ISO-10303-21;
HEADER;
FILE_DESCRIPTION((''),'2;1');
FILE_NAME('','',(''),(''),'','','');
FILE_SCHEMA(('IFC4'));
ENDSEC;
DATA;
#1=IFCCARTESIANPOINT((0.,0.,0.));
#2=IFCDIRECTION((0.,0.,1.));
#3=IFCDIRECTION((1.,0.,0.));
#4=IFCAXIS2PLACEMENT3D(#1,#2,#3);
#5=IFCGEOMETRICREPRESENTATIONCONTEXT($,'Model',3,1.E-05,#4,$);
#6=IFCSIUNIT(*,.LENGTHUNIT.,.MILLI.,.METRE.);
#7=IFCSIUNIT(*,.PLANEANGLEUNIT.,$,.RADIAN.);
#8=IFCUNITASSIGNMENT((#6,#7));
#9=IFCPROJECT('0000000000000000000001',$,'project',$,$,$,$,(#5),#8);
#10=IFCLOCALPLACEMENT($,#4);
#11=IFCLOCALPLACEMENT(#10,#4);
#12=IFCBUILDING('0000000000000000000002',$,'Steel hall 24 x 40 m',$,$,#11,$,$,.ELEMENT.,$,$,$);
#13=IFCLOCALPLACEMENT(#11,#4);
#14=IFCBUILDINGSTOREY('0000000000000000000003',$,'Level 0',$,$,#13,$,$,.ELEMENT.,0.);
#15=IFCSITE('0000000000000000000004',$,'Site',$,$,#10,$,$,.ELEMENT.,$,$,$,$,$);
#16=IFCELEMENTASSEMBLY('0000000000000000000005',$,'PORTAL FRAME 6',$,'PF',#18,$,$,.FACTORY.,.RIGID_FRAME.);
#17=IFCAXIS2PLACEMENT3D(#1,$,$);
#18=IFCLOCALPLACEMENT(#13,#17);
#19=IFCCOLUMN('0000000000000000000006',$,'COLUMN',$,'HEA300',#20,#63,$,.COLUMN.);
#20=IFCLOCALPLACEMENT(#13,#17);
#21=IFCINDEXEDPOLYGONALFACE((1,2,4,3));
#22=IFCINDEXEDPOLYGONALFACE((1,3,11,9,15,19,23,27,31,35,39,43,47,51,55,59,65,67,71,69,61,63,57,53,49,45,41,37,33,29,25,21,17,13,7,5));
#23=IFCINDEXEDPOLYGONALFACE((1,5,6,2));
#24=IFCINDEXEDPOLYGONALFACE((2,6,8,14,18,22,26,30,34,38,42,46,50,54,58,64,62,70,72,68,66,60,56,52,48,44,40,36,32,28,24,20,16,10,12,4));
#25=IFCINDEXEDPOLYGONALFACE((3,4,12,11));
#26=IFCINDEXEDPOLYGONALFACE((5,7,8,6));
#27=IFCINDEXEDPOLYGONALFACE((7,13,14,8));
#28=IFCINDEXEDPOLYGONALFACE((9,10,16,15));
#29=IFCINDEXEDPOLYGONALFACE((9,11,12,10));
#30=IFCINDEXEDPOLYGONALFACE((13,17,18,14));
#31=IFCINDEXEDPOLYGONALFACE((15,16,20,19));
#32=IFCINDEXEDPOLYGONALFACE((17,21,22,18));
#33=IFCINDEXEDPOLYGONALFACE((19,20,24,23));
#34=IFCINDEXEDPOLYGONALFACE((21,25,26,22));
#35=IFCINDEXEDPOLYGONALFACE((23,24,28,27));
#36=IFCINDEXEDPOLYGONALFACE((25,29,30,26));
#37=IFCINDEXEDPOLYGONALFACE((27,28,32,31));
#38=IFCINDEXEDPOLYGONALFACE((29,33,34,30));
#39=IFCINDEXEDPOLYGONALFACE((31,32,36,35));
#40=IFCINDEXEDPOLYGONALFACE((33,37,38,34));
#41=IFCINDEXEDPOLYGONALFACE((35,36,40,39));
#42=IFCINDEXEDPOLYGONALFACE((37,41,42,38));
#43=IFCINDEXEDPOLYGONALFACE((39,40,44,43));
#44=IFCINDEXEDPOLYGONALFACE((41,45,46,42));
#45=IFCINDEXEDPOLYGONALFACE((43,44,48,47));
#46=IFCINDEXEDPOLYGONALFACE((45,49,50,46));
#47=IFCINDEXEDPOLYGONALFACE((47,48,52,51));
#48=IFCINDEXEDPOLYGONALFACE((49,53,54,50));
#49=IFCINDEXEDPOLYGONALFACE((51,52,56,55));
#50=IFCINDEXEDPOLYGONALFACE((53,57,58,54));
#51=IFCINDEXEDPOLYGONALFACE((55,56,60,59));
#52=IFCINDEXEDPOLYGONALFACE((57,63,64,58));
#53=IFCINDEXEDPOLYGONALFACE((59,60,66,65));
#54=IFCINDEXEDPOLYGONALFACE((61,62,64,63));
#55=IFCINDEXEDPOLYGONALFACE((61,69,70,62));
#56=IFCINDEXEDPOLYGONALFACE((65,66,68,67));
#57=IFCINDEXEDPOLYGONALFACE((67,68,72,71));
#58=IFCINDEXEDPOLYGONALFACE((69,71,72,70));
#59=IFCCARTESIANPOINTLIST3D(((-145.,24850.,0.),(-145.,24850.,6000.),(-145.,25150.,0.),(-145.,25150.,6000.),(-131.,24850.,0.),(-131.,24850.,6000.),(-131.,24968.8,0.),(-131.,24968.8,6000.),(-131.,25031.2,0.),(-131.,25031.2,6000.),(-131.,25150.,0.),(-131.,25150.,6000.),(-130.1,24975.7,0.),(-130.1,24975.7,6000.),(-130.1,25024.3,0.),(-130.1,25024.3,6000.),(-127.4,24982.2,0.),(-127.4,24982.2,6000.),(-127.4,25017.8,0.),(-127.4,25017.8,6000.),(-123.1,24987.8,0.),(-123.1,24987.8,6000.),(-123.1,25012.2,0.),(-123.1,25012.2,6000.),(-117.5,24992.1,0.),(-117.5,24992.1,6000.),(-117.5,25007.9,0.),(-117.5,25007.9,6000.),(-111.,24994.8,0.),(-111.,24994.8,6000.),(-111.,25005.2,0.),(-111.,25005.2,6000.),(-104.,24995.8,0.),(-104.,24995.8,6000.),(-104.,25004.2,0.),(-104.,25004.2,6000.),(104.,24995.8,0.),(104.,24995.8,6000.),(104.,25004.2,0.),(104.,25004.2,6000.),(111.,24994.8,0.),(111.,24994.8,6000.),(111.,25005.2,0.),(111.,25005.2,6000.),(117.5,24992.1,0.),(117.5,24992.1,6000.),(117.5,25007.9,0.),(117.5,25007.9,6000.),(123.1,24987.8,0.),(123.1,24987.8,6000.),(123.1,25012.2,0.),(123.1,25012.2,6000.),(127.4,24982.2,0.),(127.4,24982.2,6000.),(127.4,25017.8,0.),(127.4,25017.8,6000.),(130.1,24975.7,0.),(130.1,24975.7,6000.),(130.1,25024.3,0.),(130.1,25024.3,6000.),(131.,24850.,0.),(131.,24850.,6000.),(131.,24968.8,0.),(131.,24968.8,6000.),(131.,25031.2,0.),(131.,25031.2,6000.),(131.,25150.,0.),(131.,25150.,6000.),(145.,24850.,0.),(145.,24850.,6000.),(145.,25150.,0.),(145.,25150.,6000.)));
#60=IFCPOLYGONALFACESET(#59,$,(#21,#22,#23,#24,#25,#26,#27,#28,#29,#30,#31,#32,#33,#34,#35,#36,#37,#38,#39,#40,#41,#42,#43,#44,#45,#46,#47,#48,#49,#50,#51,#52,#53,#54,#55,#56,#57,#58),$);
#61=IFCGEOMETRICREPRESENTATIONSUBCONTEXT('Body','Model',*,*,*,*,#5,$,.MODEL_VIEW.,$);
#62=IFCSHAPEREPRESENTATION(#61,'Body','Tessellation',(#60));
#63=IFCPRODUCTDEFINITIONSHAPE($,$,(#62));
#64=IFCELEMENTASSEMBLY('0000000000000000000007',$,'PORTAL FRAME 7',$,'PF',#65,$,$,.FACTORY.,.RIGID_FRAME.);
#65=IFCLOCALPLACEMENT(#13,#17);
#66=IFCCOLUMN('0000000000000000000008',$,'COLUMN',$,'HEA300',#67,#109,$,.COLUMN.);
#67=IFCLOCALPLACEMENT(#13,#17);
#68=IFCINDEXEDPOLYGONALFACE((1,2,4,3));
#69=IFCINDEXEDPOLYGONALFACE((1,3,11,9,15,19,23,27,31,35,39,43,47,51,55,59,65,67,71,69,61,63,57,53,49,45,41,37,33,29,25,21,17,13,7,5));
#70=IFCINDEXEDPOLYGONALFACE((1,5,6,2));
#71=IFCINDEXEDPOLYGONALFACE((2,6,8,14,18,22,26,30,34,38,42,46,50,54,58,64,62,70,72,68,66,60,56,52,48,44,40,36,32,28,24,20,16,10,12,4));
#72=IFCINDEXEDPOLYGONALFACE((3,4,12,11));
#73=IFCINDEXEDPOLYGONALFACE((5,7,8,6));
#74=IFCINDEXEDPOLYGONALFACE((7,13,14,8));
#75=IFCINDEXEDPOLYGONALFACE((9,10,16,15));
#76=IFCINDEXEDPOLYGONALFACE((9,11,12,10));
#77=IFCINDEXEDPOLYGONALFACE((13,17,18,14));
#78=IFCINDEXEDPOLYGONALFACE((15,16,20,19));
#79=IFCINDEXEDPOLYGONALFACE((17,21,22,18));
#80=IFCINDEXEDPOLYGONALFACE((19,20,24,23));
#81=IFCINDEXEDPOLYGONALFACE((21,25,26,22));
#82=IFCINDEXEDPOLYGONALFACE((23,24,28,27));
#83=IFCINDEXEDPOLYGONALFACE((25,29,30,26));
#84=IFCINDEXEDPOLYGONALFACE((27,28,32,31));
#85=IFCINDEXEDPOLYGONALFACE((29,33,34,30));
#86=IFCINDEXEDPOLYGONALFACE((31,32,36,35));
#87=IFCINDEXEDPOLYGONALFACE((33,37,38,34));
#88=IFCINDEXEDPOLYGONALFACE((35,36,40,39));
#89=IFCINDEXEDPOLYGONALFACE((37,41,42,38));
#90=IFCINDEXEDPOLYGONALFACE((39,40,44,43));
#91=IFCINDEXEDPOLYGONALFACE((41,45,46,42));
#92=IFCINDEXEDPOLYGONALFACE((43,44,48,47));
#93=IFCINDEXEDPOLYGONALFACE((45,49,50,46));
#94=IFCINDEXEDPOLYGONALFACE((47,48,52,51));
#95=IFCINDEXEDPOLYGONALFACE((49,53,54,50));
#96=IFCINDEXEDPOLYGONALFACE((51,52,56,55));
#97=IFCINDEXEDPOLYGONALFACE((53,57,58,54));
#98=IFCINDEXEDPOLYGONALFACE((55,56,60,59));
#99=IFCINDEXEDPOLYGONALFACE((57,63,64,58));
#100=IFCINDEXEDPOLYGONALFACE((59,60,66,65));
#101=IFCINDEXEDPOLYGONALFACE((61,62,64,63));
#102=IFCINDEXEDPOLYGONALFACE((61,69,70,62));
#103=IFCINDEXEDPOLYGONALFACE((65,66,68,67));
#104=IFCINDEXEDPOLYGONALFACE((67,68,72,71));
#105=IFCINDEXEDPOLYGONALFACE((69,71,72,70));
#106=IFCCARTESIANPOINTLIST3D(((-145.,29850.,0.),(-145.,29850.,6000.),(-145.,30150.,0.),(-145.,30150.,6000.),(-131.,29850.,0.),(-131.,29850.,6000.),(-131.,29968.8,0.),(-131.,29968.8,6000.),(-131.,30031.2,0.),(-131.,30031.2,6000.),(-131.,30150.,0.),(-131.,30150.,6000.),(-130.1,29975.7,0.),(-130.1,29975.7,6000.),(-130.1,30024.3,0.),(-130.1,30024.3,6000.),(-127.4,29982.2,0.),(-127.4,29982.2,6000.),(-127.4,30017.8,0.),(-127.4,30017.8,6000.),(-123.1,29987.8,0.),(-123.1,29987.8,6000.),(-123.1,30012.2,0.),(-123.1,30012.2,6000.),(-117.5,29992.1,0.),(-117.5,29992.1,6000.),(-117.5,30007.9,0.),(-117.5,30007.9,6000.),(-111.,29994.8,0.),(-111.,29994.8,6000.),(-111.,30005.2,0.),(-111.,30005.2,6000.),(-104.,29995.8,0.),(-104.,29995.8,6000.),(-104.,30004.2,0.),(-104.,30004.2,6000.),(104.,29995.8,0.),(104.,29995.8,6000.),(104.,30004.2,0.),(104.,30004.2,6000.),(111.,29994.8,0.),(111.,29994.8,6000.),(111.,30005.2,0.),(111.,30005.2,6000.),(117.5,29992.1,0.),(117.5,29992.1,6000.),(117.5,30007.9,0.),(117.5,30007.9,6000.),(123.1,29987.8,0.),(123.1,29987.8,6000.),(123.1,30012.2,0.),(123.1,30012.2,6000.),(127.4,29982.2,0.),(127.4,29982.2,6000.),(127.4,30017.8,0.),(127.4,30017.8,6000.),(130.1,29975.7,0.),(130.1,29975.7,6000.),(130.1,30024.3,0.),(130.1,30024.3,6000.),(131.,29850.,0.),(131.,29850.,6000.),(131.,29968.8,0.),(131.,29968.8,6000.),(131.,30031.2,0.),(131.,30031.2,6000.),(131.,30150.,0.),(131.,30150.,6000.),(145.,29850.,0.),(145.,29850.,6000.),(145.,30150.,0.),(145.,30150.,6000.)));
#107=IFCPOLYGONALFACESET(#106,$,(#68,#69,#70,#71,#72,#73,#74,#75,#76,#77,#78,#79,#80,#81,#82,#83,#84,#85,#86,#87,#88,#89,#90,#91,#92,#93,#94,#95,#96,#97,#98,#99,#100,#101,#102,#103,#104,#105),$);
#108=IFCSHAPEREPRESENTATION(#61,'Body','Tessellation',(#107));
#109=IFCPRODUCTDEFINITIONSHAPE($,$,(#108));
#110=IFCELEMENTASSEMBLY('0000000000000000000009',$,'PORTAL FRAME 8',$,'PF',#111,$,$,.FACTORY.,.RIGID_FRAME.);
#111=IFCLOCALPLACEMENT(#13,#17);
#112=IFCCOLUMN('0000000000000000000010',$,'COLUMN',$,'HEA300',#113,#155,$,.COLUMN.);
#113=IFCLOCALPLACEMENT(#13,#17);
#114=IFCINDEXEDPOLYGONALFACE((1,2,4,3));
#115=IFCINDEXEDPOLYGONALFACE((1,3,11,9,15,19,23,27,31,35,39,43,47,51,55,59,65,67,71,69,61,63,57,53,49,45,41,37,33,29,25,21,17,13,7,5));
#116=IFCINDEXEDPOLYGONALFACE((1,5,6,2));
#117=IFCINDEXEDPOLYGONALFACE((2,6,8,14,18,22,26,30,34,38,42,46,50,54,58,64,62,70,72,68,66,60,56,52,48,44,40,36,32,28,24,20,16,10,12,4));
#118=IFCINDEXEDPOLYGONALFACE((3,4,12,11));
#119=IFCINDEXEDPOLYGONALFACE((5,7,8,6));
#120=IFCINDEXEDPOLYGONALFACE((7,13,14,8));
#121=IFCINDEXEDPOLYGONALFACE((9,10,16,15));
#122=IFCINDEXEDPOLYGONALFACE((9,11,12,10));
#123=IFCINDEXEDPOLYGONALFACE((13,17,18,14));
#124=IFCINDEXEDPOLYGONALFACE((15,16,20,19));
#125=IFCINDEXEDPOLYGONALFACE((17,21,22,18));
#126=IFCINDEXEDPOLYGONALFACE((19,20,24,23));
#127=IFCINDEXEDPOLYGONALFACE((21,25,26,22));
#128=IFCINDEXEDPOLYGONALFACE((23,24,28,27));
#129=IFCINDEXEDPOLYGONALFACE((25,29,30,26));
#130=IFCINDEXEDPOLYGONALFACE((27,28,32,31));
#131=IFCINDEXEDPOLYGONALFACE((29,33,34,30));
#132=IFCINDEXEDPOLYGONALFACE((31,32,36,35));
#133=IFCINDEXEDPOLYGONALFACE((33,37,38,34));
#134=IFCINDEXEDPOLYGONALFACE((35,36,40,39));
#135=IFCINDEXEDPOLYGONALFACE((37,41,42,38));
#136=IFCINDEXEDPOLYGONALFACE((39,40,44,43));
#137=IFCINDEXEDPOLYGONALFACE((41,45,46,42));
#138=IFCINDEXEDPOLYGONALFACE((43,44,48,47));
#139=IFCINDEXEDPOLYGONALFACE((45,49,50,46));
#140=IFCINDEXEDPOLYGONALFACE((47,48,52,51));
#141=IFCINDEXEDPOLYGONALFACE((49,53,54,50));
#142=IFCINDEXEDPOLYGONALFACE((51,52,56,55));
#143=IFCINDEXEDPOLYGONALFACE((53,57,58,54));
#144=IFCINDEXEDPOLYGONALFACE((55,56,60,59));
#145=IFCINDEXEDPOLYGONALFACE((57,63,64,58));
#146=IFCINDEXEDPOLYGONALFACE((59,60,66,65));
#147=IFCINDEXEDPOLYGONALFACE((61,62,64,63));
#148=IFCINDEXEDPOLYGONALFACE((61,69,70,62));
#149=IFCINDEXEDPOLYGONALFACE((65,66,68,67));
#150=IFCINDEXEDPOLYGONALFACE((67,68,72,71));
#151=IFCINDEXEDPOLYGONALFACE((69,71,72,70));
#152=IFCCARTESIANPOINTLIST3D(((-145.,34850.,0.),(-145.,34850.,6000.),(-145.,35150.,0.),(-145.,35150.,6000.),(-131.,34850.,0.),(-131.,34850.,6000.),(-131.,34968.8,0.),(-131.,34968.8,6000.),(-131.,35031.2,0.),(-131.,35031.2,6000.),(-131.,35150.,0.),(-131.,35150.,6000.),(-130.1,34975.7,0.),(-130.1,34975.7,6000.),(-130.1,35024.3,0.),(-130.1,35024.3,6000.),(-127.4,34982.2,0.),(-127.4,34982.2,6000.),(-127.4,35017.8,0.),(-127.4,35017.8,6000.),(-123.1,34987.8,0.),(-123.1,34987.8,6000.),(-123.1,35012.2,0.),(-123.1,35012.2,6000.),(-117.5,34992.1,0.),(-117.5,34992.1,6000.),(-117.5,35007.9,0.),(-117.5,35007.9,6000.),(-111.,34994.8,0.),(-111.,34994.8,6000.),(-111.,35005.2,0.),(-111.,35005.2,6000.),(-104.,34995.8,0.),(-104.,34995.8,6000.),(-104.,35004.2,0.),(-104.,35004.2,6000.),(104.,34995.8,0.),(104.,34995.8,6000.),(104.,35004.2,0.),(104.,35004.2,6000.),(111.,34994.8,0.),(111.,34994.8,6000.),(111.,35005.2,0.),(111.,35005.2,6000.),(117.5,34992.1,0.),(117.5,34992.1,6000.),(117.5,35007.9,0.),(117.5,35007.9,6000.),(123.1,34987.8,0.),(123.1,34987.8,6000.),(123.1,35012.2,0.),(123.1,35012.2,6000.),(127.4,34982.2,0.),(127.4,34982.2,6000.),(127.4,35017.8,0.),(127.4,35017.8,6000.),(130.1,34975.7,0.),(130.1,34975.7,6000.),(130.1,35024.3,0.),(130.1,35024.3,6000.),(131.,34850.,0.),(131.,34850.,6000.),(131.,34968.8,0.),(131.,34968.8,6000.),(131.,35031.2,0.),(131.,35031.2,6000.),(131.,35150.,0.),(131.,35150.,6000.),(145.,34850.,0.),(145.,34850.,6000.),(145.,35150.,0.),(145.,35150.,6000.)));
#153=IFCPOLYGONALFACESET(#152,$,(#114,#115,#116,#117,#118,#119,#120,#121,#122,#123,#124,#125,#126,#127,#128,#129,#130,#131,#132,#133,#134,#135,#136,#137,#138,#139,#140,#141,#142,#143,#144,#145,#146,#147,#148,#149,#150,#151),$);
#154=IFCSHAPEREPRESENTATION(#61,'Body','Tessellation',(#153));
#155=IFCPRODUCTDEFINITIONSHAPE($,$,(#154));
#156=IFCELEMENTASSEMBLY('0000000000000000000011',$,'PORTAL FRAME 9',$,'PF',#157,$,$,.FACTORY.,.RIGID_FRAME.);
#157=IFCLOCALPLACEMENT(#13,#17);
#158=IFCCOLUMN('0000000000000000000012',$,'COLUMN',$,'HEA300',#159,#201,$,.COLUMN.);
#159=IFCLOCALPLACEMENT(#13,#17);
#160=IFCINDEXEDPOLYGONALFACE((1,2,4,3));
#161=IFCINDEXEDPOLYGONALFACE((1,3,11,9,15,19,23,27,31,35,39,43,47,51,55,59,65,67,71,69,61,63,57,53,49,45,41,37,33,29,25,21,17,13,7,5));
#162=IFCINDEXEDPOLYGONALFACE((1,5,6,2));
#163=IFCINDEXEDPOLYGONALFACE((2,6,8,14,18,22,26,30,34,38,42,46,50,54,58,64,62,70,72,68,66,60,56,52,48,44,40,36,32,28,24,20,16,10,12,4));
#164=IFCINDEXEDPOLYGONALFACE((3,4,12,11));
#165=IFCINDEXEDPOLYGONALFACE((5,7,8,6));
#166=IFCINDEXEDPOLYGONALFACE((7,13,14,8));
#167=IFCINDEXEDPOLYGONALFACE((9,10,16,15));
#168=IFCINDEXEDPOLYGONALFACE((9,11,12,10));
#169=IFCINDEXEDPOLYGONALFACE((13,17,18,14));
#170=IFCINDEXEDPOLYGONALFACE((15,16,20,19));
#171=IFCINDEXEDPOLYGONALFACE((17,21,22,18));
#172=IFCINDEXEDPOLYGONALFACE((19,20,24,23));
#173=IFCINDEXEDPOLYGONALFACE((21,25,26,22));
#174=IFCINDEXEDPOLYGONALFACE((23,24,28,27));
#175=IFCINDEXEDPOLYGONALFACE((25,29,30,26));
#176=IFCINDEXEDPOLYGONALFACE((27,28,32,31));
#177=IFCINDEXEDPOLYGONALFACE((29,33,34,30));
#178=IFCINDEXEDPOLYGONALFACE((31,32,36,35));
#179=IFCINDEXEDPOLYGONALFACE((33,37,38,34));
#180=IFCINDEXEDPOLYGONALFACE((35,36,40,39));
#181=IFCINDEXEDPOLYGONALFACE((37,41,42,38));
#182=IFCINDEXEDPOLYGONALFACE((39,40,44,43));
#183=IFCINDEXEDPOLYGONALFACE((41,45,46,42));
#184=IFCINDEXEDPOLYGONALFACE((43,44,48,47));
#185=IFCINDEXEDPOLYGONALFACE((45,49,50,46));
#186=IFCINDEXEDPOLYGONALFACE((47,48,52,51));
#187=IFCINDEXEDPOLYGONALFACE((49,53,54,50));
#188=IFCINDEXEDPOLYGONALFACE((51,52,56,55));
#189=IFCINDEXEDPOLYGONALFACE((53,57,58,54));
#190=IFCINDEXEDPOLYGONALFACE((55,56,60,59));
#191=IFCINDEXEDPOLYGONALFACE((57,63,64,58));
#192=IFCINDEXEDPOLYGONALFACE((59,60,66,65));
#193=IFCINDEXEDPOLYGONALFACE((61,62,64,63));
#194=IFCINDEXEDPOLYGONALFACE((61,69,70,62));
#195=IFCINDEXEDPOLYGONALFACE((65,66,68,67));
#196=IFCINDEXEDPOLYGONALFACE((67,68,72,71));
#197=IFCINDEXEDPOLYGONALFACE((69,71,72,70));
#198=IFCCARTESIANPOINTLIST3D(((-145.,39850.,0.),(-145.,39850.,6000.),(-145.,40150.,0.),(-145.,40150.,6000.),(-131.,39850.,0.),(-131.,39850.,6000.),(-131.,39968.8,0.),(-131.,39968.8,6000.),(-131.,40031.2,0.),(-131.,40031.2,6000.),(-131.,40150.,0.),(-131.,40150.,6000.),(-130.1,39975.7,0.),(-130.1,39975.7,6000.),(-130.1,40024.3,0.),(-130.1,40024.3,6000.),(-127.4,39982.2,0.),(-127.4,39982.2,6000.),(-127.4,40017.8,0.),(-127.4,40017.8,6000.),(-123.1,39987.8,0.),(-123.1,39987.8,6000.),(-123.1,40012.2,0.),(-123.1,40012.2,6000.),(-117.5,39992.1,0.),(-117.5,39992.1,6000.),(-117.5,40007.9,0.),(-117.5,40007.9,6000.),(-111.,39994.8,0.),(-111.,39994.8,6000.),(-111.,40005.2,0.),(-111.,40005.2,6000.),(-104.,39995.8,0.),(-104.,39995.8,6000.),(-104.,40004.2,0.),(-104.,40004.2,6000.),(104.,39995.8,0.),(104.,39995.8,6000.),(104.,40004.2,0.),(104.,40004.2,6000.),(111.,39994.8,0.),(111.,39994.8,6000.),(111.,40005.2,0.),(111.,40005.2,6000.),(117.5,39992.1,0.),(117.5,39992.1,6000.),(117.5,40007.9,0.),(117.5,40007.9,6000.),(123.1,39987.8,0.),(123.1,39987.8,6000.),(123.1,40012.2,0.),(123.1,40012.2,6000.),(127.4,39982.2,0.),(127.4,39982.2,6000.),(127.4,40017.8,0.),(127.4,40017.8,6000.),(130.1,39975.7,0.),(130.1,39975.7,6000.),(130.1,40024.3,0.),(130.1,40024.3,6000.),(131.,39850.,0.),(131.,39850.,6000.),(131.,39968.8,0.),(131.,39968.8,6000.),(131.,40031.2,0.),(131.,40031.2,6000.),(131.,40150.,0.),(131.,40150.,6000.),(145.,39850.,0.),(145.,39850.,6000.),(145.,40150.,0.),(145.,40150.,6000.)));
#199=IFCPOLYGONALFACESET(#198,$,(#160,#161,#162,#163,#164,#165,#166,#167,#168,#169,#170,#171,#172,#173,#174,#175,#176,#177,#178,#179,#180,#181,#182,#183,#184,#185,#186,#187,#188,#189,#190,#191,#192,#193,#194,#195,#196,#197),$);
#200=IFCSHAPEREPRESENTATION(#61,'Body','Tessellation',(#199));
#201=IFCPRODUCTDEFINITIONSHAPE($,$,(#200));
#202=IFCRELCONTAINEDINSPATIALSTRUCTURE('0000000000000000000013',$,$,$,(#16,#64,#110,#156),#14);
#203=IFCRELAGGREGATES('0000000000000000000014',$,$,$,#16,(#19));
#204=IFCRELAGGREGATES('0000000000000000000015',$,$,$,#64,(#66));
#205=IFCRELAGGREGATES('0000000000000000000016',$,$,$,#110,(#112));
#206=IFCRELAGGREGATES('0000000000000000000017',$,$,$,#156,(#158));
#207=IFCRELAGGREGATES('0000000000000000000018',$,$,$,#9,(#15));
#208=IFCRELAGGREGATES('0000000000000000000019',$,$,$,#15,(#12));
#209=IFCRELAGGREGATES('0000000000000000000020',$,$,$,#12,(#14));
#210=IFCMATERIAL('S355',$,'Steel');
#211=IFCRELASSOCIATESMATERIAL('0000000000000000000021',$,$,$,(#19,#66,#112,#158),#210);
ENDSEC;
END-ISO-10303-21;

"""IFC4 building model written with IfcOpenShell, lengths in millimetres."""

from ifc_helpers import new_model, si_unit, frame, origin_with_axes, place, context, subcontext, project, spatial, i_section, extrude, material, element, aggregate, save


model = new_model("IFC4")

# Units and contexts
model_context = context("Model", 3, precision=1e-05, world=origin_with_axes())
body_context = subcontext(model_context, "Body", "Model", "MODEL_VIEW")
ifc_project = project(units=[si_unit("LENGTHUNIT", "METRE", prefix="MILLI"), si_unit("PLANEANGLEUNIT", "RADIAN")], contexts=[model_context])

# Site, building, storey
site_placement = place(None, origin_with_axes())
site = spatial("IfcSite", under=ifc_project, at=site_placement, Name="Site", CompositionType="ELEMENT")
building_placement = place(site_placement, origin_with_axes())
building = spatial("IfcBuilding", under=site, at=building_placement, Name="Steel hall 24 x 40 m", CompositionType="ELEMENT")
storey_placement = place(building_placement, origin_with_axes())
storey = spatial("IfcBuildingStorey", under=building, at=storey_placement, Name="Level 0", CompositionType="ELEMENT", Elevation=0.0)

# Element assemblies, columns
assembly_1_placement = place(storey_placement, frame((0.0, 25000.0, 0.0), z_axis=(0.0, 0.0, 1.0), x_axis=(1.0, 0.0, 0.0)))
assembly_1 = element("IfcElementAssembly", 1, at=assembly_1_placement, inside=storey, Name="PORTAL FRAME 6", ObjectType="PF", AssemblyPlace="FACTORY", PredefinedType="RIGID_FRAME")
ifc_material = material(Name="S355", Category="Steel")
column_1_placement = place(storey_placement, frame((0.0, 25000.0, 0.0), z_axis=(0.0, 0.0, 1.0), x_axis=(0.0, 1.0, 0.0)))
column_1 = element("IfcColumn", 2, at=column_1_placement, material=ifc_material, Name="COLUMN", ObjectType="HEA300", PredefinedType="COLUMN", context=body_context, shape_type="SweptSolid", body=[
    extrude(i_section(OverallWidth=300.0, OverallDepth=290.0, WebThickness=8.5, FlangeThickness=14.0, FilletRadius=27.0), origin_with_axes(), (0.0, 0.0, 1.0), 6000.0),
])
assembly_2_placement = place(storey_placement, frame((0.0, 30000.0, 0.0), z_axis=(0.0, 0.0, 1.0), x_axis=(1.0, 0.0, 0.0)))
assembly_2 = element("IfcElementAssembly", 3, at=assembly_2_placement, inside=storey, Name="PORTAL FRAME 7", ObjectType="PF", AssemblyPlace="FACTORY", PredefinedType="RIGID_FRAME")
column_2_placement = place(storey_placement, frame((0.0, 30000.0, 0.0), z_axis=(0.0, 0.0, 1.0), x_axis=(0.0, 1.0, 0.0)))
column_2 = element("IfcColumn", 4, at=column_2_placement, material=ifc_material, Name="COLUMN", ObjectType="HEA300", PredefinedType="COLUMN", context=body_context, shape_type="SweptSolid", body=[
    extrude(i_section(OverallWidth=300.0, OverallDepth=290.0, WebThickness=8.5, FlangeThickness=14.0, FilletRadius=27.0), origin_with_axes(), (0.0, 0.0, 1.0), 6000.0),
])
assembly_3_placement = place(storey_placement, frame((0.0, 35000.0, 0.0), z_axis=(0.0, 0.0, 1.0), x_axis=(1.0, 0.0, 0.0)))
assembly_3 = element("IfcElementAssembly", 5, at=assembly_3_placement, inside=storey, Name="PORTAL FRAME 8", ObjectType="PF", AssemblyPlace="FACTORY", PredefinedType="RIGID_FRAME")
column_3_placement = place(storey_placement, frame((0.0, 35000.0, 0.0), z_axis=(0.0, 0.0, 1.0), x_axis=(0.0, 1.0, 0.0)))
column_3 = element("IfcColumn", 6, at=column_3_placement, material=ifc_material, Name="COLUMN", ObjectType="HEA300", PredefinedType="COLUMN", context=body_context, shape_type="SweptSolid", body=[
    extrude(i_section(OverallWidth=300.0, OverallDepth=290.0, WebThickness=8.5, FlangeThickness=14.0, FilletRadius=27.0), origin_with_axes(), (0.0, 0.0, 1.0), 6000.0),
])
assembly_4_placement = place(storey_placement, frame((0.0, 40000.0, 0.0), z_axis=(0.0, 0.0, 1.0), x_axis=(1.0, 0.0, 0.0)))
assembly_4 = element("IfcElementAssembly", 7, at=assembly_4_placement, inside=storey, Name="PORTAL FRAME 9", ObjectType="PF", AssemblyPlace="FACTORY", PredefinedType="RIGID_FRAME")
column_4_placement = place(storey_placement, frame((0.0, 40000.0, 0.0), z_axis=(0.0, 0.0, 1.0), x_axis=(0.0, 1.0, 0.0)))
column_4 = element("IfcColumn", 8, at=column_4_placement, material=ifc_material, Name="COLUMN", ObjectType="HEA300", PredefinedType="COLUMN", context=body_context, shape_type="SweptSolid", body=[
    extrude(i_section(OverallWidth=300.0, OverallDepth=290.0, WebThickness=8.5, FlangeThickness=14.0, FilletRadius=27.0), origin_with_axes(), (0.0, 0.0, 1.0), 6000.0),
])

aggregate(assembly_1, [column_1])
aggregate(assembly_2, [column_2])
aggregate(assembly_3, [column_3])
aggregate(assembly_4, [column_4])

save(model, "model.ifc")
